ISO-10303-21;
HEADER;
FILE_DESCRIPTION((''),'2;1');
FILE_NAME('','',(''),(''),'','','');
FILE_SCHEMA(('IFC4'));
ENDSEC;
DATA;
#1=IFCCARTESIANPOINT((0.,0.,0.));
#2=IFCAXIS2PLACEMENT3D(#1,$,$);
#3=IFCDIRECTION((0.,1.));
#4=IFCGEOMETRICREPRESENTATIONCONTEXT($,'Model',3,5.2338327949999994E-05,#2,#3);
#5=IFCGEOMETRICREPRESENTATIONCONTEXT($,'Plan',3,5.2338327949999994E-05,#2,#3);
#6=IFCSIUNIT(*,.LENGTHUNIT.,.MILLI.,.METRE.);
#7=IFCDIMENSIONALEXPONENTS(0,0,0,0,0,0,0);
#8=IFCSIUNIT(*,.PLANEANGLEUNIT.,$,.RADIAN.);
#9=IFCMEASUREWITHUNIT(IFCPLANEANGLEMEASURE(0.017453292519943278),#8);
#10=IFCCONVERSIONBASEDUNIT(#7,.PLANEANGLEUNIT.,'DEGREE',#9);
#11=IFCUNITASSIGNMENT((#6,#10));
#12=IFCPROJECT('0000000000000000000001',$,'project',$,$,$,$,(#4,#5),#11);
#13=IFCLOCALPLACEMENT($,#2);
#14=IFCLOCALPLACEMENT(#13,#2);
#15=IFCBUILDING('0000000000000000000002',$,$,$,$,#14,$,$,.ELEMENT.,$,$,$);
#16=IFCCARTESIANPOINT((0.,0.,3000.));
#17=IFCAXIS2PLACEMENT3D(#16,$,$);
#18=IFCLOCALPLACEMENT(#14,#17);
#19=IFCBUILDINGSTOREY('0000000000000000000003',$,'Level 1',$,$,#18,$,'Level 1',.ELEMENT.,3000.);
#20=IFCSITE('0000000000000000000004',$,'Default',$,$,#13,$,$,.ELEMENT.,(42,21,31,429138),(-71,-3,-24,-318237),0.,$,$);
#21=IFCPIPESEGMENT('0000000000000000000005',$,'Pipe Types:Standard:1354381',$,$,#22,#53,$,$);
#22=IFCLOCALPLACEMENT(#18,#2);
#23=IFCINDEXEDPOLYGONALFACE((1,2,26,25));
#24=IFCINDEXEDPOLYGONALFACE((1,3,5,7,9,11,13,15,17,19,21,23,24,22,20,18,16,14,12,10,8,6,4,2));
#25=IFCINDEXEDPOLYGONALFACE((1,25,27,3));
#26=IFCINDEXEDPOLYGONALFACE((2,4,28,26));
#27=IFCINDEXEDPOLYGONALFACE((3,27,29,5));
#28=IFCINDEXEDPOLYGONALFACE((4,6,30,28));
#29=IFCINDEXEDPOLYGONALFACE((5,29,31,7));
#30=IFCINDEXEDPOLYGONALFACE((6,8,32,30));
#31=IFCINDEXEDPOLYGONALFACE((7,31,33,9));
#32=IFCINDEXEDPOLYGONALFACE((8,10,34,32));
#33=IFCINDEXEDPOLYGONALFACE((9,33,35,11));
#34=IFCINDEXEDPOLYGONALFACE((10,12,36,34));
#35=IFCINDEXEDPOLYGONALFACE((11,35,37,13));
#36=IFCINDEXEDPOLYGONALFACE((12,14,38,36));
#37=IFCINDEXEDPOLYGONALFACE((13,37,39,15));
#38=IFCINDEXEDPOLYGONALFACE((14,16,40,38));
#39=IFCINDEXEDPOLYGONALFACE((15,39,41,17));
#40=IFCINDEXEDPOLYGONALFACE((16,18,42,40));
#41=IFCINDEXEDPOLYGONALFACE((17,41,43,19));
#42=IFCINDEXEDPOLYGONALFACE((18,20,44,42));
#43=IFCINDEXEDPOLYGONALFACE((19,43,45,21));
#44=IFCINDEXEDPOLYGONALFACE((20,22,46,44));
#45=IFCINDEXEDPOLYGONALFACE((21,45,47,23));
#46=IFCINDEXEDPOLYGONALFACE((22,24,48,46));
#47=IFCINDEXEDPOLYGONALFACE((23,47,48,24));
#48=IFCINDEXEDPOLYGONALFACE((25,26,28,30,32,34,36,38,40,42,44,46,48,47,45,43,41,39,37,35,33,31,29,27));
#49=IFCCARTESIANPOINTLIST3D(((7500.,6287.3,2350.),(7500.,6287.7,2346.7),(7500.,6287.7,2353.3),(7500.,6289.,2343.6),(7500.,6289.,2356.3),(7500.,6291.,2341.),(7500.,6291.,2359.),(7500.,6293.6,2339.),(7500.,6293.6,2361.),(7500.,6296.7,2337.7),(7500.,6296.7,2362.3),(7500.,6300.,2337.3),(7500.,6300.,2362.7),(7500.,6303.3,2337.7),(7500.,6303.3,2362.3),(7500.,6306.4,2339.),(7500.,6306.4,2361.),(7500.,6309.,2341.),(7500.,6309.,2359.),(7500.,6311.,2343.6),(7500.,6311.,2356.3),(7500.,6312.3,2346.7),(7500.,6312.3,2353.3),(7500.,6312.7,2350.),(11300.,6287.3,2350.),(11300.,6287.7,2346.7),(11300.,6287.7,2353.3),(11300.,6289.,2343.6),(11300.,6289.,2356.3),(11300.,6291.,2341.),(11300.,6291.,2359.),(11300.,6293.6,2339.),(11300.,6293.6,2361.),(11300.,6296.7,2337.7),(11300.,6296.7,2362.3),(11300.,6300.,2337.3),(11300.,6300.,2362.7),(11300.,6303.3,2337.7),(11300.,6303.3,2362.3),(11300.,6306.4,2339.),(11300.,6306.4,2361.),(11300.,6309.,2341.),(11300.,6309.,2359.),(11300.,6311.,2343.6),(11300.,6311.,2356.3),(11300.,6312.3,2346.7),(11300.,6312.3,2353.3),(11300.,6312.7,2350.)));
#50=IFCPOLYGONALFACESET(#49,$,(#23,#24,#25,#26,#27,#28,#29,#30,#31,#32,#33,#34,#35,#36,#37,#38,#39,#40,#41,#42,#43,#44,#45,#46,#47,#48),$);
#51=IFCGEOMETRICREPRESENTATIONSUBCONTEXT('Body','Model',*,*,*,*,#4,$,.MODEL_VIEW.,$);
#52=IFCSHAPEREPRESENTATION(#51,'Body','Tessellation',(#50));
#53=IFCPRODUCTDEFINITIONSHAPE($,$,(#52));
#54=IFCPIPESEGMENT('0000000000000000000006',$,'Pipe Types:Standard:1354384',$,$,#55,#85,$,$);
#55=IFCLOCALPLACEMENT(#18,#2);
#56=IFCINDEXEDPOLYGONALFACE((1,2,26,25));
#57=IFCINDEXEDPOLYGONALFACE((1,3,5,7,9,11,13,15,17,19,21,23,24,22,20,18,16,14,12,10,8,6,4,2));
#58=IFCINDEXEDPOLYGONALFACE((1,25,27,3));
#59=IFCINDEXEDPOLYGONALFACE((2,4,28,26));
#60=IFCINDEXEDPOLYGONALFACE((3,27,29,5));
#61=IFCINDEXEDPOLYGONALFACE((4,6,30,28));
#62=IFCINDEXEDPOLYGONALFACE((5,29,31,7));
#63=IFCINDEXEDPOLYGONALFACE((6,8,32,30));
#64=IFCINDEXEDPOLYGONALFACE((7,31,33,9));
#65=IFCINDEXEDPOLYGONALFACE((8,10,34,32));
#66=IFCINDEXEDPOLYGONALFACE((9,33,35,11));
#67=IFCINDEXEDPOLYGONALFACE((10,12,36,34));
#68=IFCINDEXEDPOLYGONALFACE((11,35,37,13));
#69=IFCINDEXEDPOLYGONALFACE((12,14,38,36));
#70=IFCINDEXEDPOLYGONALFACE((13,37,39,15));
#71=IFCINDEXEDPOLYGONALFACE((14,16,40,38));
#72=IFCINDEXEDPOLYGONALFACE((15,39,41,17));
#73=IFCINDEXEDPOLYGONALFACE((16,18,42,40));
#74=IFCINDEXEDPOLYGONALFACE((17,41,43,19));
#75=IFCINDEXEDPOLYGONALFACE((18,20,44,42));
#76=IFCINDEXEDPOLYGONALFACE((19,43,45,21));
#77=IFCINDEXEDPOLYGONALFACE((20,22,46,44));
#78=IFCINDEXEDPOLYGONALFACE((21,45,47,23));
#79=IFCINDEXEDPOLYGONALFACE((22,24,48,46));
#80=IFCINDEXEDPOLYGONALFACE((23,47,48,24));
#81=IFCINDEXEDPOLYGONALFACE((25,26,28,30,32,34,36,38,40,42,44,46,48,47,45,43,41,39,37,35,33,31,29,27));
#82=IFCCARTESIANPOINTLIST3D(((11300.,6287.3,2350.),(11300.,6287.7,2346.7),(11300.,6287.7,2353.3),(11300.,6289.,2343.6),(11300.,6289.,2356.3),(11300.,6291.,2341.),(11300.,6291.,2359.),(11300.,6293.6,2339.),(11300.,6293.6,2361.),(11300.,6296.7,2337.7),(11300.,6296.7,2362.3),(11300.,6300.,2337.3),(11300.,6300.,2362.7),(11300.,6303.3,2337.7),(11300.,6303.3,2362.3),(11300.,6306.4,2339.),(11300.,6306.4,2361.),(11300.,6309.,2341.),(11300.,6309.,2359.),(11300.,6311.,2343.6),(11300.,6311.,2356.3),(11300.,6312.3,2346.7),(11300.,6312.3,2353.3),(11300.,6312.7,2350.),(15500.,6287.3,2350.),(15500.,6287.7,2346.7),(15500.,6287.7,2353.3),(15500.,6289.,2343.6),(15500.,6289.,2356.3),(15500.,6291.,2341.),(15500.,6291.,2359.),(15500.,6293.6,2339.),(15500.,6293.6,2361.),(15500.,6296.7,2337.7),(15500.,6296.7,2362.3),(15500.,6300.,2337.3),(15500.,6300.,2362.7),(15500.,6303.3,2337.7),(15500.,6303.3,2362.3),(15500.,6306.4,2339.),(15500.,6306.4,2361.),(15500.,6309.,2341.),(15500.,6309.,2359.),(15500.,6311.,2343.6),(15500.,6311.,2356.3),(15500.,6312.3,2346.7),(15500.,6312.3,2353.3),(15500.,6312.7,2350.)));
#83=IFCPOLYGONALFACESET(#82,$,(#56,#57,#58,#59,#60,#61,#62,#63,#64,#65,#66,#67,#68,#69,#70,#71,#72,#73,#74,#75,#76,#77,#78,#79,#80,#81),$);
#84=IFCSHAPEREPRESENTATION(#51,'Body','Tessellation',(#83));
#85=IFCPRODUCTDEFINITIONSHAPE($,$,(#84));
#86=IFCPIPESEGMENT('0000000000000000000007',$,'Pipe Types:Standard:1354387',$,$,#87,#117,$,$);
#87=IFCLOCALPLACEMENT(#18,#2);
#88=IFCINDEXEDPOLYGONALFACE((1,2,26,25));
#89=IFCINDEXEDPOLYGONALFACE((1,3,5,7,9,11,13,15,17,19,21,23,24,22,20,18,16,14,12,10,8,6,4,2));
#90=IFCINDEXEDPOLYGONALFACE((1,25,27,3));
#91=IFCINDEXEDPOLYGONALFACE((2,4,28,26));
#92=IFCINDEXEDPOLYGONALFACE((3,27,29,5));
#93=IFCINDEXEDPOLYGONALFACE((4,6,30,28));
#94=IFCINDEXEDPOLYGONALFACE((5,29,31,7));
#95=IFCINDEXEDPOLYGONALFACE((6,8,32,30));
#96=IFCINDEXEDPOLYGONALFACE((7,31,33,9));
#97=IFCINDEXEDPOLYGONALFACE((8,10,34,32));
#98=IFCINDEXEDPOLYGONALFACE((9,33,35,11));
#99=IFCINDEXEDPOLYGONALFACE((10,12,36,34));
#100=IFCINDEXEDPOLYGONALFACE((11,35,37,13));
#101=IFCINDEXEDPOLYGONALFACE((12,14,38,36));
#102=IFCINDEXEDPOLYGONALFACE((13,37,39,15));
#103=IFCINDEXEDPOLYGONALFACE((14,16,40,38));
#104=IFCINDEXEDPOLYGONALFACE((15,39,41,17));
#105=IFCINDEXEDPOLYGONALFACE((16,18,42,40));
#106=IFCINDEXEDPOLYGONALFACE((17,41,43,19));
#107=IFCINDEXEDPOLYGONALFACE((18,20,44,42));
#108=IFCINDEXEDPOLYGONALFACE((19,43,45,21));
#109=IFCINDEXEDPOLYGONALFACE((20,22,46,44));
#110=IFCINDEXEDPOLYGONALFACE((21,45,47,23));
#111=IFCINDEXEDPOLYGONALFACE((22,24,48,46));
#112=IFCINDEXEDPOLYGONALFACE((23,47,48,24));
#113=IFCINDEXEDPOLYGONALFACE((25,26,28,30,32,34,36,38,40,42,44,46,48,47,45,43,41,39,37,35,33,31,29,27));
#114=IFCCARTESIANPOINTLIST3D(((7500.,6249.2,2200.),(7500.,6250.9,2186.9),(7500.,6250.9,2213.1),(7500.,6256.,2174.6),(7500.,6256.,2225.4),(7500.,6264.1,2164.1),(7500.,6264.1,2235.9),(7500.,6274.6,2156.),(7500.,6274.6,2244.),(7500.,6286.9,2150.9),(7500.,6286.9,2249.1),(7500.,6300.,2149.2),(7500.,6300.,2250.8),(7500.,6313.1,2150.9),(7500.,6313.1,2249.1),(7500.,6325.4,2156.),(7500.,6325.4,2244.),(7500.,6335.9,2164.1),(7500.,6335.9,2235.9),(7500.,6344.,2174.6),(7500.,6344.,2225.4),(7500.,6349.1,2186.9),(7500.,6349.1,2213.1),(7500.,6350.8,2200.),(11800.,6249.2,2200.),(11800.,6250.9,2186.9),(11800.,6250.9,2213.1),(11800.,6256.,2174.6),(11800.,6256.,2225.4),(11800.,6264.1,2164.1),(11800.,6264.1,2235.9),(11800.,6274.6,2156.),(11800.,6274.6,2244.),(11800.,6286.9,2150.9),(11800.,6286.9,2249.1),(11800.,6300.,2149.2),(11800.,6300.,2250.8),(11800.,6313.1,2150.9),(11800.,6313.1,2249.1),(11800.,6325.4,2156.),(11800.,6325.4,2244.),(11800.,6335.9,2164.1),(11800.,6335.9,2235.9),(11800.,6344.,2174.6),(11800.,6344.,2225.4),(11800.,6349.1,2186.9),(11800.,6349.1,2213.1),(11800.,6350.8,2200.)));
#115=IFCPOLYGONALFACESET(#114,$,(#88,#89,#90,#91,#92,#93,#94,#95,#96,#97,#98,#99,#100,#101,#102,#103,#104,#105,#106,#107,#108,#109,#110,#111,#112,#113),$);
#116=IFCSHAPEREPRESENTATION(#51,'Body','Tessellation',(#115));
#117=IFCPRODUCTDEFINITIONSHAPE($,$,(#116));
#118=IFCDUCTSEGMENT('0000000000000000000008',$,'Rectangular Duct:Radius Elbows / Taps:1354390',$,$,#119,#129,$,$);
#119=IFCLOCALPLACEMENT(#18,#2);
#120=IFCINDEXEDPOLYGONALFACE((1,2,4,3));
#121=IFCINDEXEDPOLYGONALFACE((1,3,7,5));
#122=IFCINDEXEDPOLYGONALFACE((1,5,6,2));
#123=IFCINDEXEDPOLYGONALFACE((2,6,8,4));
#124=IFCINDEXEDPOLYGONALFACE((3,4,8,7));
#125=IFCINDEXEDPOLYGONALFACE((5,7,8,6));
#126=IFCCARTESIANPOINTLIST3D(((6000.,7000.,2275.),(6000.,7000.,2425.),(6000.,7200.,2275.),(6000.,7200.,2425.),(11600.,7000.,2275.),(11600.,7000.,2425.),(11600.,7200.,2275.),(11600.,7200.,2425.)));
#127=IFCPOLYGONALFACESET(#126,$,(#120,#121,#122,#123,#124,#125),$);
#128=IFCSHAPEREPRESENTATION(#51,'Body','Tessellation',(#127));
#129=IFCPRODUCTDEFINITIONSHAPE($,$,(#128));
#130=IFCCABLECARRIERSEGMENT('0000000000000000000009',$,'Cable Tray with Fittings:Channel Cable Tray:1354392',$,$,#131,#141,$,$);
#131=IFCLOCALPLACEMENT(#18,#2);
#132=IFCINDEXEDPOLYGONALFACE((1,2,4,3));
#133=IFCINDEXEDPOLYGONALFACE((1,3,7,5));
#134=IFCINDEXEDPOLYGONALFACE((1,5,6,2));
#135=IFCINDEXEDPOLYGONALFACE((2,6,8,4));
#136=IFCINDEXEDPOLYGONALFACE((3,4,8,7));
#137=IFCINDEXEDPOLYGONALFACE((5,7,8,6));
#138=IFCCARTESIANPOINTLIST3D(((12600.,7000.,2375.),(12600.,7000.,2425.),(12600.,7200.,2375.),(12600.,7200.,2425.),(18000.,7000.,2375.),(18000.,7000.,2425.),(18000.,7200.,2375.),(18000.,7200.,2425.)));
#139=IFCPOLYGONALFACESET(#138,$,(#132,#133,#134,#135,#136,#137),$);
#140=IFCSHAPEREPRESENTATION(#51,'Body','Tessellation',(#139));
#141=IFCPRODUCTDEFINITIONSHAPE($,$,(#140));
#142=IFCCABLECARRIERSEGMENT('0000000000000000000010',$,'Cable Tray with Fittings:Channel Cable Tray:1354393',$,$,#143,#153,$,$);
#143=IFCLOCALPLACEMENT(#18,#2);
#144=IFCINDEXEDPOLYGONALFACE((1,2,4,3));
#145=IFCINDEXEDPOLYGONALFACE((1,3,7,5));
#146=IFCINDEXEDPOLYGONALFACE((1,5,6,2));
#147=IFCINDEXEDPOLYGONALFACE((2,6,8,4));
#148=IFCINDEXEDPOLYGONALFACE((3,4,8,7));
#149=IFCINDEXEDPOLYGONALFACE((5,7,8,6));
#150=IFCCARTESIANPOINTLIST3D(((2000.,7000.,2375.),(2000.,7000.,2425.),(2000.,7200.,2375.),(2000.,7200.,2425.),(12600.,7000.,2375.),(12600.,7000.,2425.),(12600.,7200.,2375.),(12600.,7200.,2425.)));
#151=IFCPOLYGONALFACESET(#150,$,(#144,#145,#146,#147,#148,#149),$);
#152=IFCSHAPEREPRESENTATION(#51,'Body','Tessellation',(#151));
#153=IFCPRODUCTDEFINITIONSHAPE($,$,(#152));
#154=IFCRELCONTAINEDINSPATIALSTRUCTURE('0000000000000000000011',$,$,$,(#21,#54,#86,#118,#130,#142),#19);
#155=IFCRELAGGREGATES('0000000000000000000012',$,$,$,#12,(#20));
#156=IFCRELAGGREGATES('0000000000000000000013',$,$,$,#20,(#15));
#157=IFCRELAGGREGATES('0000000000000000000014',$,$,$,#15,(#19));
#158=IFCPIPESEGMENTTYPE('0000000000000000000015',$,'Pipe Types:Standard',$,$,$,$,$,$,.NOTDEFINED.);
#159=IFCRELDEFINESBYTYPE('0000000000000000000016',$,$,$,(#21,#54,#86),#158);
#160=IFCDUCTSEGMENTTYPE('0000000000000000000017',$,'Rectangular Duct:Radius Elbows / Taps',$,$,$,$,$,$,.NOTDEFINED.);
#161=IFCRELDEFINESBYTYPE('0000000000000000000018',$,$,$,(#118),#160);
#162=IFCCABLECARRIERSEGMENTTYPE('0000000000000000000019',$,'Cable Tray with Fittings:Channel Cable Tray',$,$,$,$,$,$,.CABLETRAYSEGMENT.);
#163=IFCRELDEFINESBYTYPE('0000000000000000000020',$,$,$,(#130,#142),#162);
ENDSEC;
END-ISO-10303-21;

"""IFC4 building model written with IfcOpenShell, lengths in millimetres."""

from ifc_helpers import new_model, entity, si_unit, converted_unit, direction, frame, origin, place, context, subcontext, project, spatial, arc, indexed_curve, outline, extrude, type_object, element, save


model = new_model("IFC4")

# Units and contexts
model_context = context("Model", 3, precision=5.2338327949999994e-05, world=origin(), true_north=direction((0.0, 1.0)))
plan_context = context("Plan", 3, precision=5.2338327949999994e-05, world=origin(), true_north=direction((0.0, 1.0)))
body_context = subcontext(model_context, "Body", "Model", "MODEL_VIEW")
ifc_project = project(units=[si_unit("LENGTHUNIT", "METRE", prefix="MILLI"), converted_unit("PLANEANGLEUNIT", "DEGREE", entity("IfcPlaneAngleMeasure", 0.017453292519943278), si_unit("PLANEANGLEUNIT", "RADIAN"), dimensions=[0, 0, 0, 0, 0, 0, 0])], contexts=[model_context, plan_context])

# Site, building, storey
site_placement = place(None, origin())
site = spatial("IfcSite", under=ifc_project, at=site_placement, Name="Default", CompositionType="ELEMENT", RefLatitude=(42, 21, 31, 429138), RefLongitude=(-71, -3, -24, -318237), RefElevation=0.0)
building_placement = place(site_placement, origin())
building = spatial("IfcBuilding", under=site, at=building_placement, CompositionType="ELEMENT")
storey_placement = place(building_placement, frame((0.0, 0.0, 3000.0)))
storey = spatial("IfcBuildingStorey", under=building, at=storey_placement, Name="Level 1", LongName="Level 1", CompositionType="ELEMENT", Elevation=3000.0)

# Pipe segments
pipe_segment_type = type_object("IfcPipeSegmentType", Name="Pipe Types:Standard", PredefinedType="NOTDEFINED")
pipe_segment_1_placement = place(storey_placement, origin())
element("IfcPipeSegment", 1, at=pipe_segment_1_placement, inside=storey, type_object=pipe_segment_type, Name="Pipe Types:Standard:1354381", context=body_context, shape_type="SweptSolid", body=[
    extrude(outline(indexed_curve([(12.7, 0.0), (9.0, 9.0), (0.0, 12.7), (-9.0, 9.0), (-12.7, 0.0), (-9.0, -9.0), (0.0, -12.7), (9.0, -9.0)], segments=[arc(1, 2, 3), arc(3, 4, 5), arc(5, 6, 7), arc(7, 8, 1)], self_intersect=False)), frame((7500.0, 6300.0, 2350.0), z_axis=(1.0, 0.0, 0.0), x_axis=(0.0, 1.0, 0.0)), (0.0, 0.0, 1.0), 3800.0),
])
pipe_segment_2_placement = place(storey_placement, origin())
element("IfcPipeSegment", 2, at=pipe_segment_2_placement, inside=storey, type_object=pipe_segment_type, Name="Pipe Types:Standard:1354384", context=body_context, shape_type="SweptSolid", body=[
    extrude(outline(indexed_curve([(12.7, 0.0), (9.0, 9.0), (0.0, 12.7), (-9.0, 9.0), (-12.7, 0.0), (-9.0, -9.0), (0.0, -12.7), (9.0, -9.0)], segments=[arc(1, 2, 3), arc(3, 4, 5), arc(5, 6, 7), arc(7, 8, 1)], self_intersect=False)), frame((11300.0, 6300.0, 2350.0), z_axis=(1.0, 0.0, 0.0), x_axis=(0.0, -1.0, 0.0)), (0.0, 0.0, 1.0), 4200.0),
])
pipe_segment_3_placement = place(storey_placement, origin())
element("IfcPipeSegment", 3, at=pipe_segment_3_placement, inside=storey, type_object=pipe_segment_type, Name="Pipe Types:Standard:1354387", context=body_context, shape_type="SweptSolid", body=[
    extrude(outline(indexed_curve([(50.8, 0.0), (35.9, 35.9), (0.0, 50.8), (-35.9, 35.9), (-50.8, 0.0), (-35.9, -35.9), (0.0, -50.8), (35.9, -35.9)], segments=[arc(1, 2, 3), arc(3, 4, 5), arc(5, 6, 7), arc(7, 8, 1)], self_intersect=False)), frame((7500.0, 6300.0, 2200.0), z_axis=(1.0, 0.0, 0.0), x_axis=(0.0, 1.0, 0.0)), (0.0, 0.0, 1.0), 4300.0),
])

# Duct segment
duct_segment_type = type_object("IfcDuctSegmentType", Name="Rectangular Duct:Radius Elbows / Taps", PredefinedType="NOTDEFINED")
duct_segment_placement = place(storey_placement, origin())
element("IfcDuctSegment", 4, at=duct_segment_placement, inside=storey, type_object=duct_segment_type, Name="Rectangular Duct:Radius Elbows / Taps:1354390", context=body_context, shape_type="SweptSolid", body=[
    extrude(outline(indexed_curve([(-2800.0, -100.0), (2800.0, -100.0), (2800.0, 100.0), (-2800.0, 100.0), (-2800.0, -100.0)], self_intersect=False)), frame((8800.0, 7100.0, 2275.0), z_axis=(0.0, 0.0, 1.0), x_axis=(-1.0, 0.0, 0.0)), (0.0, 0.0, 1.0), 150.0),
])

# Cable carrier segments
cable_carrier_segment_type = type_object("IfcCableCarrierSegmentType", Name="Cable Tray with Fittings:Channel Cable Tray", PredefinedType="CABLETRAYSEGMENT")
cable_carrier_segment_1_placement = place(storey_placement, origin())
element("IfcCableCarrierSegment", 5, at=cable_carrier_segment_1_placement, inside=storey, type_object=cable_carrier_segment_type, Name="Cable Tray with Fittings:Channel Cable Tray:1354392", context=body_context, shape_type="SweptSolid", body=[
    extrude(outline(indexed_curve([(-2700.0, -100.0), (2700.0, -100.0), (2700.0, 100.0), (-2700.0, 100.0), (-2700.0, -100.0)], self_intersect=False)), frame((15300.0, 7100.0, 2375.0)), (0.0, 0.0, 1.0), 50.0),
])
cable_carrier_segment_2_placement = place(storey_placement, origin())
element("IfcCableCarrierSegment", 6, at=cable_carrier_segment_2_placement, inside=storey, type_object=cable_carrier_segment_type, Name="Cable Tray with Fittings:Channel Cable Tray:1354393", context=body_context, shape_type="SweptSolid", body=[
    extrude(outline(indexed_curve([(-5300.0, -100.0), (5300.0, -100.0), (5300.0, 100.0), (-5300.0, 100.0), (-5300.0, -100.0)], self_intersect=False)), frame((7300.0, 7100.0, 2375.0), z_axis=(0.0, 0.0, 1.0), x_axis=(-1.0, 0.0, 0.0)), (0.0, 0.0, 1.0), 50.0),
])

save(model, "model.ifc")
